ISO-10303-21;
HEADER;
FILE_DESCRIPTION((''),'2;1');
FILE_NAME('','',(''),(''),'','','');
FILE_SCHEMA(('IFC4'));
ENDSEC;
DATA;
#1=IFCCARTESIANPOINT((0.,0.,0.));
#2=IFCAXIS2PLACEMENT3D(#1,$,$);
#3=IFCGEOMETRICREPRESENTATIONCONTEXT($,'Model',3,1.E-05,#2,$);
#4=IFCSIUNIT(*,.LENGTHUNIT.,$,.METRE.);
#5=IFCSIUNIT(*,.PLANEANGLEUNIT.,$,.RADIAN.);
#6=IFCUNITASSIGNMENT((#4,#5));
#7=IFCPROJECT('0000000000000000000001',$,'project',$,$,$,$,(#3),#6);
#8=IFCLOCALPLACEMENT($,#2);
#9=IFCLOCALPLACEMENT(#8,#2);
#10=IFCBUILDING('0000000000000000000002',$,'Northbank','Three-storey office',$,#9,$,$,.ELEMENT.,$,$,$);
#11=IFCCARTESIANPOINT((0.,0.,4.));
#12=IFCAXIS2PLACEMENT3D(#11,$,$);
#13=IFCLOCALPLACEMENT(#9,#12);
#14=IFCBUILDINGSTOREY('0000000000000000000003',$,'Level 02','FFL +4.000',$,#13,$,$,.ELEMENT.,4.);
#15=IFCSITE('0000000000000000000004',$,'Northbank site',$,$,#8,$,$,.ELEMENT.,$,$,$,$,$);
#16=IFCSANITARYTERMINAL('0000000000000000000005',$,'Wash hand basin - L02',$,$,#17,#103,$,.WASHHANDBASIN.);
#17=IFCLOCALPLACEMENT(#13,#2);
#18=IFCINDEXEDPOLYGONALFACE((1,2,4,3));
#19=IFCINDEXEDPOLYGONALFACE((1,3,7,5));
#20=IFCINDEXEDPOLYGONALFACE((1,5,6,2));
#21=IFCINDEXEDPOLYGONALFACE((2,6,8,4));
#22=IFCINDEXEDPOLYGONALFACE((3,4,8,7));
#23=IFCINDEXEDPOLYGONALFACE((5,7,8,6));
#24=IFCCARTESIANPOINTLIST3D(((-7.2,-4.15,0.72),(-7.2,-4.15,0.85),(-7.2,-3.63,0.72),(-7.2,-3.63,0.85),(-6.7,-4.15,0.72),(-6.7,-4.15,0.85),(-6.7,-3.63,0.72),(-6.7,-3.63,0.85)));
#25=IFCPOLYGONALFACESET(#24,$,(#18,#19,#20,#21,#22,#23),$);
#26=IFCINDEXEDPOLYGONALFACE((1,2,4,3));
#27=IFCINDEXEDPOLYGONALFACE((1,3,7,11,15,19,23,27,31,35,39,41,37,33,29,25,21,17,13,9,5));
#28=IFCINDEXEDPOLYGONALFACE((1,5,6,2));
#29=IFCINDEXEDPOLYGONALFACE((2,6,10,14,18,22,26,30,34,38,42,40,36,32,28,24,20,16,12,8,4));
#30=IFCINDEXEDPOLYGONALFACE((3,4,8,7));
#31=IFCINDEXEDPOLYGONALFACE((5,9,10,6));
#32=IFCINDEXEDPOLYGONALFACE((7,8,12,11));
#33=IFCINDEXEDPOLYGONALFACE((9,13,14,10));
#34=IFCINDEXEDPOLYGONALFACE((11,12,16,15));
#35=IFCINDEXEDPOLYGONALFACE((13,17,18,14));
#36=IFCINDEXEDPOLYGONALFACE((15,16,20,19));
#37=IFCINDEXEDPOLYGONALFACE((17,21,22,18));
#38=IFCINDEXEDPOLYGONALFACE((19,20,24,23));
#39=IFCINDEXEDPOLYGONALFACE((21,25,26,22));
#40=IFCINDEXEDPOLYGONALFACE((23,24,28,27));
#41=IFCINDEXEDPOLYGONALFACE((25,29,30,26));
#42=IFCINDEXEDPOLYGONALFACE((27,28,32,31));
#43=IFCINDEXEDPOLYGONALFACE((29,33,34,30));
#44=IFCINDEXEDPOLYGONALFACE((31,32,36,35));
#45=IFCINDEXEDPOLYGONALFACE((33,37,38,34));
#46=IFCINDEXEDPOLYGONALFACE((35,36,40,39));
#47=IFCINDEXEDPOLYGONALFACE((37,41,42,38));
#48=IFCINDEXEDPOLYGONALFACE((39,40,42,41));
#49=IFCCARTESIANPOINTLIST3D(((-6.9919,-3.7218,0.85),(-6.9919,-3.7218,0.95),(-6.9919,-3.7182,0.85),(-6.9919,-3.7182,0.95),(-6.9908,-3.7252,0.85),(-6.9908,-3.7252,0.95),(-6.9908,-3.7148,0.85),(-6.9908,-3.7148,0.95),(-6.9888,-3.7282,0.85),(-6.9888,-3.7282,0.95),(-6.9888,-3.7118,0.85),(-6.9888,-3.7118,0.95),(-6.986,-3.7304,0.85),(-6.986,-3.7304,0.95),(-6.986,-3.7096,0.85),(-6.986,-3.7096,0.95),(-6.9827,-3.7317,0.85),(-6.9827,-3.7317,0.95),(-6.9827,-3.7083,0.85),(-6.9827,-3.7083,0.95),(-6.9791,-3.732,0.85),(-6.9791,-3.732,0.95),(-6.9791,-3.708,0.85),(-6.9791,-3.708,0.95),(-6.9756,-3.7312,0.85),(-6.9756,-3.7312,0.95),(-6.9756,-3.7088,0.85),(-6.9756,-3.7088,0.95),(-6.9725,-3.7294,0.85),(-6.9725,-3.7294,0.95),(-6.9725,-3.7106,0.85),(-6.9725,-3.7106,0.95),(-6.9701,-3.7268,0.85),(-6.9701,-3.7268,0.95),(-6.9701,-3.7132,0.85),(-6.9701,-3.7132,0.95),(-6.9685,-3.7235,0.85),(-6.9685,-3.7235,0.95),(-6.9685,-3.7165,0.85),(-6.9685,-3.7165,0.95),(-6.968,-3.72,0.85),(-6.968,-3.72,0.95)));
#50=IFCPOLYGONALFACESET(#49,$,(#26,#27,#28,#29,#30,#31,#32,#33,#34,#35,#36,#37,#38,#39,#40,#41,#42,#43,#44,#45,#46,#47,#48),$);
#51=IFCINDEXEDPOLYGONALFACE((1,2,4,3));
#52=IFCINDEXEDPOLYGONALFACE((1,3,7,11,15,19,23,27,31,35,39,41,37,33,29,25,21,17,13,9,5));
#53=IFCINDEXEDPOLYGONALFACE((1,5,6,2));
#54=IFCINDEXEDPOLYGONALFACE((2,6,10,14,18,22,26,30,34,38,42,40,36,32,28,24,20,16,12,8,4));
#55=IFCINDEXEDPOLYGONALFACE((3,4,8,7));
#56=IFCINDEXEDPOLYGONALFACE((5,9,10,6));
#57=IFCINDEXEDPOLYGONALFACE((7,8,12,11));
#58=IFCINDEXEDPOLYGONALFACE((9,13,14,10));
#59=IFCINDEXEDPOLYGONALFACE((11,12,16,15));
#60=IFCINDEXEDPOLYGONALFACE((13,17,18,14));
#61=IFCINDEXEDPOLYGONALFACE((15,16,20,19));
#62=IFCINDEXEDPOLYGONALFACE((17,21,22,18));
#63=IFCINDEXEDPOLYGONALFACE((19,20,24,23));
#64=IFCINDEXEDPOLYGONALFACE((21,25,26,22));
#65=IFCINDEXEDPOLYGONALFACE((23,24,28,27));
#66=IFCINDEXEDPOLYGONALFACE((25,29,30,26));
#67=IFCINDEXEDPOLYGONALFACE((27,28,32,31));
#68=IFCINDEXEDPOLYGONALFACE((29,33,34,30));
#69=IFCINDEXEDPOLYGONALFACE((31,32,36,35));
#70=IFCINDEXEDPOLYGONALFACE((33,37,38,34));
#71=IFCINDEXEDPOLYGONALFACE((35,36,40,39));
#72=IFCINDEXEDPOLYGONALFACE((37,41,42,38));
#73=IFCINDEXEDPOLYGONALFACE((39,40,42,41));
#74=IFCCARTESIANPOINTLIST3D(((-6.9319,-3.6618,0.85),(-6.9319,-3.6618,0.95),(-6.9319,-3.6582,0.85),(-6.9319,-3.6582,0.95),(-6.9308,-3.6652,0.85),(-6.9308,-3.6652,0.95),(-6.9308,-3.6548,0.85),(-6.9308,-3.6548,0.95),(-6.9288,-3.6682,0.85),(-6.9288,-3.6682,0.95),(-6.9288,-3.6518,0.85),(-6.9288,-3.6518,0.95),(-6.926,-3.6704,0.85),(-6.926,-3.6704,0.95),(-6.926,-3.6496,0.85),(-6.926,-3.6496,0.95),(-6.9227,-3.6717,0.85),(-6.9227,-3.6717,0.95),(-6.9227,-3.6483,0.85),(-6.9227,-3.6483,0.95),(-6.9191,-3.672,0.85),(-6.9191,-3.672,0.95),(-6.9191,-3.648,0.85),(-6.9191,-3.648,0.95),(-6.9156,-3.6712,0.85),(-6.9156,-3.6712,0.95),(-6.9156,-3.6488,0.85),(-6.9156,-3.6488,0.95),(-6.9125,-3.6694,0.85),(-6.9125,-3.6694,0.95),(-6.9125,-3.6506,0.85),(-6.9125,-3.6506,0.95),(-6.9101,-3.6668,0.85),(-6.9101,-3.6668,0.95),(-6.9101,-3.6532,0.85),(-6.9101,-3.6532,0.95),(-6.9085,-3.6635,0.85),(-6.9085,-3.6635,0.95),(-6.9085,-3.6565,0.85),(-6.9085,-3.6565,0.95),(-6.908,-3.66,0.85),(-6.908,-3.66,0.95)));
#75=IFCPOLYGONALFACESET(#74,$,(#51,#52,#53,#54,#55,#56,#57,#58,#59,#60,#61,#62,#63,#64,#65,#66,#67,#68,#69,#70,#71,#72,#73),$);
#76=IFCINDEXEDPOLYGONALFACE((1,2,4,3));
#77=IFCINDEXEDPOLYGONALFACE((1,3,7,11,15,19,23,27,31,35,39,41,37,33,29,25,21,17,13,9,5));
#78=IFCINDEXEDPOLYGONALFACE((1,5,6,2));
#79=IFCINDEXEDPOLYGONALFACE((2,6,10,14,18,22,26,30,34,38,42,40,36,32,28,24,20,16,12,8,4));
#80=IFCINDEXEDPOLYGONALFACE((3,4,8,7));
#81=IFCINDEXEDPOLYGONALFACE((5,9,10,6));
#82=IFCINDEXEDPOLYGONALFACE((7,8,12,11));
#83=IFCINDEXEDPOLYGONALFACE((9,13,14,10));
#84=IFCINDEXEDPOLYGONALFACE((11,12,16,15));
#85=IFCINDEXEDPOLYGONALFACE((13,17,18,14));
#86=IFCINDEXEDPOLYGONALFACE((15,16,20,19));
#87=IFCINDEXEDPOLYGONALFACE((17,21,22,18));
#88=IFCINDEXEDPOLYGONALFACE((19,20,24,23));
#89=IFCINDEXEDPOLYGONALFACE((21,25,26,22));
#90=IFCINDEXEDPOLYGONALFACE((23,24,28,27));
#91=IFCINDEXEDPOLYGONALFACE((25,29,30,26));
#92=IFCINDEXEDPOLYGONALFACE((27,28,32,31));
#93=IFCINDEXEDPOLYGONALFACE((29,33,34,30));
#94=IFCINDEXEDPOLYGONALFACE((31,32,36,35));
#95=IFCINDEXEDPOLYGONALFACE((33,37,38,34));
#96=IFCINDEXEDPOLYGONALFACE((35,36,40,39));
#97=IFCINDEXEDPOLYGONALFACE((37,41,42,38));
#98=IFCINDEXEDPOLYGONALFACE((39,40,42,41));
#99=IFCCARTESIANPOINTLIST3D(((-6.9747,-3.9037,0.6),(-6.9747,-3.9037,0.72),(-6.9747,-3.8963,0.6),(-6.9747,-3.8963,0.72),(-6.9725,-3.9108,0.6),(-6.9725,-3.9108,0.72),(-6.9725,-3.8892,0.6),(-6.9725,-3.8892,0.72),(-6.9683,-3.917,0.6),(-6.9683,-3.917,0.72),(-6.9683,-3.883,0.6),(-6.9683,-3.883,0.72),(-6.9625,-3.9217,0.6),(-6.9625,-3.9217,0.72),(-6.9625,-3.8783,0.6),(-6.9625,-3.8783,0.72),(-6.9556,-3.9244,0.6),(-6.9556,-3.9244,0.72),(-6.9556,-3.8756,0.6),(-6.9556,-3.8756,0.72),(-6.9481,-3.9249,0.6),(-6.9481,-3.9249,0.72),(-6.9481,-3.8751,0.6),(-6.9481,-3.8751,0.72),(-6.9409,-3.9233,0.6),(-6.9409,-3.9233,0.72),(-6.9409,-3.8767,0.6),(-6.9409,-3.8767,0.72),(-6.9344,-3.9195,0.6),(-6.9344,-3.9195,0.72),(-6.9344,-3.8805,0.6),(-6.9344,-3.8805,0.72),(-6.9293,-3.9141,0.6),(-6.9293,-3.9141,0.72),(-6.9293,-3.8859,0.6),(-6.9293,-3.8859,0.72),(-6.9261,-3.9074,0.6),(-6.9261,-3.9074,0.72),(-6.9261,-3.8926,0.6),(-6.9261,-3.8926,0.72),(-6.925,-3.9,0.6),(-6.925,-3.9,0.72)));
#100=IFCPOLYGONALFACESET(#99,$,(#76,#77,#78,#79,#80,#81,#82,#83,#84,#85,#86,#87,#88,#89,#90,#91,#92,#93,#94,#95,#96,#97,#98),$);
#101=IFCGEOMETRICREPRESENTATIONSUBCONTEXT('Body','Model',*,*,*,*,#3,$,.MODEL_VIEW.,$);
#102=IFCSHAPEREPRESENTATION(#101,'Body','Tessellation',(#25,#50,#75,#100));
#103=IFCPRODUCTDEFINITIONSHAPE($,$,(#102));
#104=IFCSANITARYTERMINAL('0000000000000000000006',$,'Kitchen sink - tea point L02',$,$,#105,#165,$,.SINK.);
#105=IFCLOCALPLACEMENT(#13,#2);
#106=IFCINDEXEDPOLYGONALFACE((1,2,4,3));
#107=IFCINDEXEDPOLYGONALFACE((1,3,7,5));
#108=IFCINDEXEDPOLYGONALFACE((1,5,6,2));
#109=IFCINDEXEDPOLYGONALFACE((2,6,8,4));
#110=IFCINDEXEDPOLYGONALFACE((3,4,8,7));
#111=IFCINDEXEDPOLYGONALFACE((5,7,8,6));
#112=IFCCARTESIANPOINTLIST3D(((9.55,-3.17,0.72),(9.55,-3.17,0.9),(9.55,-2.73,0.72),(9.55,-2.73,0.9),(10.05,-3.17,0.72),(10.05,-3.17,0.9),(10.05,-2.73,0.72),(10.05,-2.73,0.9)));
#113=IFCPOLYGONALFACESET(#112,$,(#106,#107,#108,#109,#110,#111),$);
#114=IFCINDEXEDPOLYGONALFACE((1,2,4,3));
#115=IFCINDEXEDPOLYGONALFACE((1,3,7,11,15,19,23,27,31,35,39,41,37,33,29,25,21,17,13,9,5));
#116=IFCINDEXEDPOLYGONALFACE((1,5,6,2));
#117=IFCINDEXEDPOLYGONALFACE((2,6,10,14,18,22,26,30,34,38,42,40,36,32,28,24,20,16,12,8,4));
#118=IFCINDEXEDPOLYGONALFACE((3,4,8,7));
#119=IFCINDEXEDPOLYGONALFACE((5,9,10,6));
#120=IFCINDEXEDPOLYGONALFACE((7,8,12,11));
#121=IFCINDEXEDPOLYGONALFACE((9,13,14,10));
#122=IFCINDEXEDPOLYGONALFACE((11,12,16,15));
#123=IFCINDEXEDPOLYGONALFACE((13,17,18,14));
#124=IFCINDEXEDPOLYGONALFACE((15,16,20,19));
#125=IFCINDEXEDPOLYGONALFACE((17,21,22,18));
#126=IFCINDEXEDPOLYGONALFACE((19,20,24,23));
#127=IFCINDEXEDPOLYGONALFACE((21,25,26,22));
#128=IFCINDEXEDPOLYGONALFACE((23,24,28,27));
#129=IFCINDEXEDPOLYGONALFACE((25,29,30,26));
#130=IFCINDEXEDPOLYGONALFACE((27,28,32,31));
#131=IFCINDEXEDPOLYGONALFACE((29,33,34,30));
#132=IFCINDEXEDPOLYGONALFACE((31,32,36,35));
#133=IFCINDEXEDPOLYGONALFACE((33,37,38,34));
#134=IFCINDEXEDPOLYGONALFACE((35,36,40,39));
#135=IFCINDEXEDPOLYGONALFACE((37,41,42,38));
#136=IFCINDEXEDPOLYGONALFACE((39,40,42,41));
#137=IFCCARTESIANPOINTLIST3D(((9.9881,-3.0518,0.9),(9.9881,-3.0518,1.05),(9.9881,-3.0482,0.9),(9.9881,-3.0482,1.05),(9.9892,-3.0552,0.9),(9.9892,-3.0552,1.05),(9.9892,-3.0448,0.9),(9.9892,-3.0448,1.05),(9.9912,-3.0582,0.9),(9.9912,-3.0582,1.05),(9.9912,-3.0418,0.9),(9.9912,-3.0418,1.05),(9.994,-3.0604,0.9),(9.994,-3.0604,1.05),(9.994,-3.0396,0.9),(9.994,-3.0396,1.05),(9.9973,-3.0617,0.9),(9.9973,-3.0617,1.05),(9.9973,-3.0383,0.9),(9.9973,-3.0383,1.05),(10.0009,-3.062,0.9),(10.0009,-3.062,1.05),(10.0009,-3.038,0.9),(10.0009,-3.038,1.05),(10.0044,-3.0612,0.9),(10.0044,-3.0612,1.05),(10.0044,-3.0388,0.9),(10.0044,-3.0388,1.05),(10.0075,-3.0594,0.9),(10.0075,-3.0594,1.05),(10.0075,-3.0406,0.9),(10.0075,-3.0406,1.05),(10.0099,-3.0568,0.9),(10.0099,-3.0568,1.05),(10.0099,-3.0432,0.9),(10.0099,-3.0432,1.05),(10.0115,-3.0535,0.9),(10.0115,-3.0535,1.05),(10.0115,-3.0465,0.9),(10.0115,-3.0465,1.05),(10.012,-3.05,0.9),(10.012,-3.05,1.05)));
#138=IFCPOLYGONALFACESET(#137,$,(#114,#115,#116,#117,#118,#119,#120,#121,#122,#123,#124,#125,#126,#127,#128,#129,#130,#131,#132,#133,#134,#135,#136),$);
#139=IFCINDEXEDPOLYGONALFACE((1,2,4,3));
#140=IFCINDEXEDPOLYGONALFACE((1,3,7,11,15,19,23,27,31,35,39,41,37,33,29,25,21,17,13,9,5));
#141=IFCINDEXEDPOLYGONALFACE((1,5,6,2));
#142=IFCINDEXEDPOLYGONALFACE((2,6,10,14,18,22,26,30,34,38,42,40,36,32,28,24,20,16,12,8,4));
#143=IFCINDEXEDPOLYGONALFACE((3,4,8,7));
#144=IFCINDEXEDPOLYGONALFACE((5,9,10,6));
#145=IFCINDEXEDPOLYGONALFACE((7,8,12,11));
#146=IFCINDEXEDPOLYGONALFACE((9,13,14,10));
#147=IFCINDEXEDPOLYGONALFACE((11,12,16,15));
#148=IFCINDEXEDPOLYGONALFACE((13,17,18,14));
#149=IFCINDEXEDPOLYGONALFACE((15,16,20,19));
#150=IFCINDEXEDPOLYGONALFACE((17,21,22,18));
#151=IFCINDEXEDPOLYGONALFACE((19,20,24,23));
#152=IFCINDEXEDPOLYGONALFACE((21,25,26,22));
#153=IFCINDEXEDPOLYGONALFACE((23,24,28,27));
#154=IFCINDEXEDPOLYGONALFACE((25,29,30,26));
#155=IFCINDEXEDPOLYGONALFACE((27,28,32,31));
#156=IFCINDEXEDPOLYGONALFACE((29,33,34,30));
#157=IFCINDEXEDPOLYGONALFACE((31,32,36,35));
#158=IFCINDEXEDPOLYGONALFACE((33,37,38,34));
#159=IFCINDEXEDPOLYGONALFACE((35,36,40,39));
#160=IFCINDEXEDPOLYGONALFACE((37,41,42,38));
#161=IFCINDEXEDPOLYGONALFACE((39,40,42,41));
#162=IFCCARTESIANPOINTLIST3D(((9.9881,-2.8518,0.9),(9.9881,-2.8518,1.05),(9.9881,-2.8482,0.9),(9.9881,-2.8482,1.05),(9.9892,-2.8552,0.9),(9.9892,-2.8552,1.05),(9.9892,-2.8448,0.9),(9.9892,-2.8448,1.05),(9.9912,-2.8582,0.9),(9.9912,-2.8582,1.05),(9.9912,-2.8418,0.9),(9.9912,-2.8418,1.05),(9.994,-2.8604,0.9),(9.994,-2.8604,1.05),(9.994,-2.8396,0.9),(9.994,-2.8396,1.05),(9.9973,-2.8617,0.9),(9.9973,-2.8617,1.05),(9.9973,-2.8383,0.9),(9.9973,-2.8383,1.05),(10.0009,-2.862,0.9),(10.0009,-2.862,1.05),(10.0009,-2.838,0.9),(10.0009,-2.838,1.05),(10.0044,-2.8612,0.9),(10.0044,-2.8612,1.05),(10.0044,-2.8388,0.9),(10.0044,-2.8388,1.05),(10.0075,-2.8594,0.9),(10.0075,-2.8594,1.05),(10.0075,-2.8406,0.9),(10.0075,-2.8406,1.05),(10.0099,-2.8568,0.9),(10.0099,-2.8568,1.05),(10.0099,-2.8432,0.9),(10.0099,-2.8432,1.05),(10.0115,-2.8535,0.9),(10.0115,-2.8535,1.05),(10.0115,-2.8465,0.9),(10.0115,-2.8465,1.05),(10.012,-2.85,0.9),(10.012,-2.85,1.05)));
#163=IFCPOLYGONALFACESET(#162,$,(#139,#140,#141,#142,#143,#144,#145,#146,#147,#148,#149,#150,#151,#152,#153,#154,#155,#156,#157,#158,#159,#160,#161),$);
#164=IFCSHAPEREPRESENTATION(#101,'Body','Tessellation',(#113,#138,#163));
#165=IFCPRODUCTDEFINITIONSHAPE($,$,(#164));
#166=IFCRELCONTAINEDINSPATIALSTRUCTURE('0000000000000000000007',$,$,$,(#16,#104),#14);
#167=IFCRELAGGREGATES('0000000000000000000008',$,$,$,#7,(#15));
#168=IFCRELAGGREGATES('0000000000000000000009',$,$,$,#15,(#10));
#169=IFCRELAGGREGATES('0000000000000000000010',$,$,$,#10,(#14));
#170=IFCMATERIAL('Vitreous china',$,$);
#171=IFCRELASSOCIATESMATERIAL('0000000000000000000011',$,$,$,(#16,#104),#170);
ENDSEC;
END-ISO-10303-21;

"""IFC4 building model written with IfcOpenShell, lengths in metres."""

from ifc_helpers import new_model, si_unit, frame, origin, place, context, subcontext, project, spatial, rectangle, circle, extrude, material, element, save


model = new_model("IFC4")

# Units and contexts
model_context = context("Model", 3, precision=1e-05, world=origin())
body_context = subcontext(model_context, "Body", "Model", "MODEL_VIEW")
ifc_project = project(units=[si_unit("LENGTHUNIT", "METRE"), si_unit("PLANEANGLEUNIT", "RADIAN")], contexts=[model_context])

# Site, building, storey
site_placement = place(None, origin())
site = spatial("IfcSite", under=ifc_project, at=site_placement, Name="Northbank site", CompositionType="ELEMENT")
building_placement = place(site_placement, origin())
building = spatial("IfcBuilding", under=site, at=building_placement, Name="Northbank", Description="Three-storey office", CompositionType="ELEMENT")
storey_placement = place(building_placement, frame((0.0, 0.0, 4.0)))
storey = spatial("IfcBuildingStorey", under=building, at=storey_placement, Name="Level 02", Description="FFL +4.000", CompositionType="ELEMENT", Elevation=4.0)

# Sanitary terminals
ifc_material_1 = material(Name="Vitreous china")
sanitary_terminal_1_placement = place(storey_placement, frame((0.0, 0.0, -4.0)))
element("IfcSanitaryTerminal", 1, at=sanitary_terminal_1_placement, inside=storey, material=ifc_material_1, Name="Wash hand basin - L02", PredefinedType="WASHHANDBASIN", context=body_context, shape_type="SweptSolid", body=[
    extrude(rectangle(XDim=0.5, YDim=0.52), frame((-6.95, -3.89, 4.72)), (0.0, 0.0, 1.0), 0.13),
    extrude(circle(Radius=0.012), frame((-6.98, -3.72, 4.85), z_axis=(0.0, 0.0, 1.0), x_axis=(1.0, 0.0, 0.0)), (0.0, 0.0, 1.0), 0.1),
    extrude(circle(Radius=0.012), frame((-6.92, -3.66, 4.85), z_axis=(0.0, 0.0, 1.0), x_axis=(1.0, 0.0, 0.0)), (0.0, 0.0, 1.0), 0.1),
    extrude(circle(Radius=0.025), frame((-6.95, -3.9, 4.72), z_axis=(0.0, 0.0, -1.0), x_axis=(1.0, 0.0, 0.0)), (0.0, 0.0, 1.0), 0.12),
])
sanitary_terminal_2_placement = place(storey_placement, frame((0.0, 0.0, -4.0)))
element("IfcSanitaryTerminal", 2, at=sanitary_terminal_2_placement, inside=storey, material=ifc_material_1, Name="Kitchen sink - tea point L02", PredefinedType="SINK", context=body_context, shape_type="SweptSolid", body=[
    extrude(rectangle(XDim=0.5, YDim=0.44), frame((9.8, -2.95, 4.72)), (0.0, 0.0, 1.0), 0.18),
    extrude(circle(Radius=0.012), frame((10.0, -3.05, 4.9), z_axis=(0.0, 0.0, 1.0), x_axis=(1.0, 0.0, 0.0)), (0.0, 0.0, 1.0), 0.15),
    extrude(circle(Radius=0.012), frame((10.0, -2.85, 4.9), z_axis=(0.0, 0.0, 1.0), x_axis=(1.0, 0.0, 0.0)), (0.0, 0.0, 1.0), 0.15),
])

save(model, "model.ifc")
